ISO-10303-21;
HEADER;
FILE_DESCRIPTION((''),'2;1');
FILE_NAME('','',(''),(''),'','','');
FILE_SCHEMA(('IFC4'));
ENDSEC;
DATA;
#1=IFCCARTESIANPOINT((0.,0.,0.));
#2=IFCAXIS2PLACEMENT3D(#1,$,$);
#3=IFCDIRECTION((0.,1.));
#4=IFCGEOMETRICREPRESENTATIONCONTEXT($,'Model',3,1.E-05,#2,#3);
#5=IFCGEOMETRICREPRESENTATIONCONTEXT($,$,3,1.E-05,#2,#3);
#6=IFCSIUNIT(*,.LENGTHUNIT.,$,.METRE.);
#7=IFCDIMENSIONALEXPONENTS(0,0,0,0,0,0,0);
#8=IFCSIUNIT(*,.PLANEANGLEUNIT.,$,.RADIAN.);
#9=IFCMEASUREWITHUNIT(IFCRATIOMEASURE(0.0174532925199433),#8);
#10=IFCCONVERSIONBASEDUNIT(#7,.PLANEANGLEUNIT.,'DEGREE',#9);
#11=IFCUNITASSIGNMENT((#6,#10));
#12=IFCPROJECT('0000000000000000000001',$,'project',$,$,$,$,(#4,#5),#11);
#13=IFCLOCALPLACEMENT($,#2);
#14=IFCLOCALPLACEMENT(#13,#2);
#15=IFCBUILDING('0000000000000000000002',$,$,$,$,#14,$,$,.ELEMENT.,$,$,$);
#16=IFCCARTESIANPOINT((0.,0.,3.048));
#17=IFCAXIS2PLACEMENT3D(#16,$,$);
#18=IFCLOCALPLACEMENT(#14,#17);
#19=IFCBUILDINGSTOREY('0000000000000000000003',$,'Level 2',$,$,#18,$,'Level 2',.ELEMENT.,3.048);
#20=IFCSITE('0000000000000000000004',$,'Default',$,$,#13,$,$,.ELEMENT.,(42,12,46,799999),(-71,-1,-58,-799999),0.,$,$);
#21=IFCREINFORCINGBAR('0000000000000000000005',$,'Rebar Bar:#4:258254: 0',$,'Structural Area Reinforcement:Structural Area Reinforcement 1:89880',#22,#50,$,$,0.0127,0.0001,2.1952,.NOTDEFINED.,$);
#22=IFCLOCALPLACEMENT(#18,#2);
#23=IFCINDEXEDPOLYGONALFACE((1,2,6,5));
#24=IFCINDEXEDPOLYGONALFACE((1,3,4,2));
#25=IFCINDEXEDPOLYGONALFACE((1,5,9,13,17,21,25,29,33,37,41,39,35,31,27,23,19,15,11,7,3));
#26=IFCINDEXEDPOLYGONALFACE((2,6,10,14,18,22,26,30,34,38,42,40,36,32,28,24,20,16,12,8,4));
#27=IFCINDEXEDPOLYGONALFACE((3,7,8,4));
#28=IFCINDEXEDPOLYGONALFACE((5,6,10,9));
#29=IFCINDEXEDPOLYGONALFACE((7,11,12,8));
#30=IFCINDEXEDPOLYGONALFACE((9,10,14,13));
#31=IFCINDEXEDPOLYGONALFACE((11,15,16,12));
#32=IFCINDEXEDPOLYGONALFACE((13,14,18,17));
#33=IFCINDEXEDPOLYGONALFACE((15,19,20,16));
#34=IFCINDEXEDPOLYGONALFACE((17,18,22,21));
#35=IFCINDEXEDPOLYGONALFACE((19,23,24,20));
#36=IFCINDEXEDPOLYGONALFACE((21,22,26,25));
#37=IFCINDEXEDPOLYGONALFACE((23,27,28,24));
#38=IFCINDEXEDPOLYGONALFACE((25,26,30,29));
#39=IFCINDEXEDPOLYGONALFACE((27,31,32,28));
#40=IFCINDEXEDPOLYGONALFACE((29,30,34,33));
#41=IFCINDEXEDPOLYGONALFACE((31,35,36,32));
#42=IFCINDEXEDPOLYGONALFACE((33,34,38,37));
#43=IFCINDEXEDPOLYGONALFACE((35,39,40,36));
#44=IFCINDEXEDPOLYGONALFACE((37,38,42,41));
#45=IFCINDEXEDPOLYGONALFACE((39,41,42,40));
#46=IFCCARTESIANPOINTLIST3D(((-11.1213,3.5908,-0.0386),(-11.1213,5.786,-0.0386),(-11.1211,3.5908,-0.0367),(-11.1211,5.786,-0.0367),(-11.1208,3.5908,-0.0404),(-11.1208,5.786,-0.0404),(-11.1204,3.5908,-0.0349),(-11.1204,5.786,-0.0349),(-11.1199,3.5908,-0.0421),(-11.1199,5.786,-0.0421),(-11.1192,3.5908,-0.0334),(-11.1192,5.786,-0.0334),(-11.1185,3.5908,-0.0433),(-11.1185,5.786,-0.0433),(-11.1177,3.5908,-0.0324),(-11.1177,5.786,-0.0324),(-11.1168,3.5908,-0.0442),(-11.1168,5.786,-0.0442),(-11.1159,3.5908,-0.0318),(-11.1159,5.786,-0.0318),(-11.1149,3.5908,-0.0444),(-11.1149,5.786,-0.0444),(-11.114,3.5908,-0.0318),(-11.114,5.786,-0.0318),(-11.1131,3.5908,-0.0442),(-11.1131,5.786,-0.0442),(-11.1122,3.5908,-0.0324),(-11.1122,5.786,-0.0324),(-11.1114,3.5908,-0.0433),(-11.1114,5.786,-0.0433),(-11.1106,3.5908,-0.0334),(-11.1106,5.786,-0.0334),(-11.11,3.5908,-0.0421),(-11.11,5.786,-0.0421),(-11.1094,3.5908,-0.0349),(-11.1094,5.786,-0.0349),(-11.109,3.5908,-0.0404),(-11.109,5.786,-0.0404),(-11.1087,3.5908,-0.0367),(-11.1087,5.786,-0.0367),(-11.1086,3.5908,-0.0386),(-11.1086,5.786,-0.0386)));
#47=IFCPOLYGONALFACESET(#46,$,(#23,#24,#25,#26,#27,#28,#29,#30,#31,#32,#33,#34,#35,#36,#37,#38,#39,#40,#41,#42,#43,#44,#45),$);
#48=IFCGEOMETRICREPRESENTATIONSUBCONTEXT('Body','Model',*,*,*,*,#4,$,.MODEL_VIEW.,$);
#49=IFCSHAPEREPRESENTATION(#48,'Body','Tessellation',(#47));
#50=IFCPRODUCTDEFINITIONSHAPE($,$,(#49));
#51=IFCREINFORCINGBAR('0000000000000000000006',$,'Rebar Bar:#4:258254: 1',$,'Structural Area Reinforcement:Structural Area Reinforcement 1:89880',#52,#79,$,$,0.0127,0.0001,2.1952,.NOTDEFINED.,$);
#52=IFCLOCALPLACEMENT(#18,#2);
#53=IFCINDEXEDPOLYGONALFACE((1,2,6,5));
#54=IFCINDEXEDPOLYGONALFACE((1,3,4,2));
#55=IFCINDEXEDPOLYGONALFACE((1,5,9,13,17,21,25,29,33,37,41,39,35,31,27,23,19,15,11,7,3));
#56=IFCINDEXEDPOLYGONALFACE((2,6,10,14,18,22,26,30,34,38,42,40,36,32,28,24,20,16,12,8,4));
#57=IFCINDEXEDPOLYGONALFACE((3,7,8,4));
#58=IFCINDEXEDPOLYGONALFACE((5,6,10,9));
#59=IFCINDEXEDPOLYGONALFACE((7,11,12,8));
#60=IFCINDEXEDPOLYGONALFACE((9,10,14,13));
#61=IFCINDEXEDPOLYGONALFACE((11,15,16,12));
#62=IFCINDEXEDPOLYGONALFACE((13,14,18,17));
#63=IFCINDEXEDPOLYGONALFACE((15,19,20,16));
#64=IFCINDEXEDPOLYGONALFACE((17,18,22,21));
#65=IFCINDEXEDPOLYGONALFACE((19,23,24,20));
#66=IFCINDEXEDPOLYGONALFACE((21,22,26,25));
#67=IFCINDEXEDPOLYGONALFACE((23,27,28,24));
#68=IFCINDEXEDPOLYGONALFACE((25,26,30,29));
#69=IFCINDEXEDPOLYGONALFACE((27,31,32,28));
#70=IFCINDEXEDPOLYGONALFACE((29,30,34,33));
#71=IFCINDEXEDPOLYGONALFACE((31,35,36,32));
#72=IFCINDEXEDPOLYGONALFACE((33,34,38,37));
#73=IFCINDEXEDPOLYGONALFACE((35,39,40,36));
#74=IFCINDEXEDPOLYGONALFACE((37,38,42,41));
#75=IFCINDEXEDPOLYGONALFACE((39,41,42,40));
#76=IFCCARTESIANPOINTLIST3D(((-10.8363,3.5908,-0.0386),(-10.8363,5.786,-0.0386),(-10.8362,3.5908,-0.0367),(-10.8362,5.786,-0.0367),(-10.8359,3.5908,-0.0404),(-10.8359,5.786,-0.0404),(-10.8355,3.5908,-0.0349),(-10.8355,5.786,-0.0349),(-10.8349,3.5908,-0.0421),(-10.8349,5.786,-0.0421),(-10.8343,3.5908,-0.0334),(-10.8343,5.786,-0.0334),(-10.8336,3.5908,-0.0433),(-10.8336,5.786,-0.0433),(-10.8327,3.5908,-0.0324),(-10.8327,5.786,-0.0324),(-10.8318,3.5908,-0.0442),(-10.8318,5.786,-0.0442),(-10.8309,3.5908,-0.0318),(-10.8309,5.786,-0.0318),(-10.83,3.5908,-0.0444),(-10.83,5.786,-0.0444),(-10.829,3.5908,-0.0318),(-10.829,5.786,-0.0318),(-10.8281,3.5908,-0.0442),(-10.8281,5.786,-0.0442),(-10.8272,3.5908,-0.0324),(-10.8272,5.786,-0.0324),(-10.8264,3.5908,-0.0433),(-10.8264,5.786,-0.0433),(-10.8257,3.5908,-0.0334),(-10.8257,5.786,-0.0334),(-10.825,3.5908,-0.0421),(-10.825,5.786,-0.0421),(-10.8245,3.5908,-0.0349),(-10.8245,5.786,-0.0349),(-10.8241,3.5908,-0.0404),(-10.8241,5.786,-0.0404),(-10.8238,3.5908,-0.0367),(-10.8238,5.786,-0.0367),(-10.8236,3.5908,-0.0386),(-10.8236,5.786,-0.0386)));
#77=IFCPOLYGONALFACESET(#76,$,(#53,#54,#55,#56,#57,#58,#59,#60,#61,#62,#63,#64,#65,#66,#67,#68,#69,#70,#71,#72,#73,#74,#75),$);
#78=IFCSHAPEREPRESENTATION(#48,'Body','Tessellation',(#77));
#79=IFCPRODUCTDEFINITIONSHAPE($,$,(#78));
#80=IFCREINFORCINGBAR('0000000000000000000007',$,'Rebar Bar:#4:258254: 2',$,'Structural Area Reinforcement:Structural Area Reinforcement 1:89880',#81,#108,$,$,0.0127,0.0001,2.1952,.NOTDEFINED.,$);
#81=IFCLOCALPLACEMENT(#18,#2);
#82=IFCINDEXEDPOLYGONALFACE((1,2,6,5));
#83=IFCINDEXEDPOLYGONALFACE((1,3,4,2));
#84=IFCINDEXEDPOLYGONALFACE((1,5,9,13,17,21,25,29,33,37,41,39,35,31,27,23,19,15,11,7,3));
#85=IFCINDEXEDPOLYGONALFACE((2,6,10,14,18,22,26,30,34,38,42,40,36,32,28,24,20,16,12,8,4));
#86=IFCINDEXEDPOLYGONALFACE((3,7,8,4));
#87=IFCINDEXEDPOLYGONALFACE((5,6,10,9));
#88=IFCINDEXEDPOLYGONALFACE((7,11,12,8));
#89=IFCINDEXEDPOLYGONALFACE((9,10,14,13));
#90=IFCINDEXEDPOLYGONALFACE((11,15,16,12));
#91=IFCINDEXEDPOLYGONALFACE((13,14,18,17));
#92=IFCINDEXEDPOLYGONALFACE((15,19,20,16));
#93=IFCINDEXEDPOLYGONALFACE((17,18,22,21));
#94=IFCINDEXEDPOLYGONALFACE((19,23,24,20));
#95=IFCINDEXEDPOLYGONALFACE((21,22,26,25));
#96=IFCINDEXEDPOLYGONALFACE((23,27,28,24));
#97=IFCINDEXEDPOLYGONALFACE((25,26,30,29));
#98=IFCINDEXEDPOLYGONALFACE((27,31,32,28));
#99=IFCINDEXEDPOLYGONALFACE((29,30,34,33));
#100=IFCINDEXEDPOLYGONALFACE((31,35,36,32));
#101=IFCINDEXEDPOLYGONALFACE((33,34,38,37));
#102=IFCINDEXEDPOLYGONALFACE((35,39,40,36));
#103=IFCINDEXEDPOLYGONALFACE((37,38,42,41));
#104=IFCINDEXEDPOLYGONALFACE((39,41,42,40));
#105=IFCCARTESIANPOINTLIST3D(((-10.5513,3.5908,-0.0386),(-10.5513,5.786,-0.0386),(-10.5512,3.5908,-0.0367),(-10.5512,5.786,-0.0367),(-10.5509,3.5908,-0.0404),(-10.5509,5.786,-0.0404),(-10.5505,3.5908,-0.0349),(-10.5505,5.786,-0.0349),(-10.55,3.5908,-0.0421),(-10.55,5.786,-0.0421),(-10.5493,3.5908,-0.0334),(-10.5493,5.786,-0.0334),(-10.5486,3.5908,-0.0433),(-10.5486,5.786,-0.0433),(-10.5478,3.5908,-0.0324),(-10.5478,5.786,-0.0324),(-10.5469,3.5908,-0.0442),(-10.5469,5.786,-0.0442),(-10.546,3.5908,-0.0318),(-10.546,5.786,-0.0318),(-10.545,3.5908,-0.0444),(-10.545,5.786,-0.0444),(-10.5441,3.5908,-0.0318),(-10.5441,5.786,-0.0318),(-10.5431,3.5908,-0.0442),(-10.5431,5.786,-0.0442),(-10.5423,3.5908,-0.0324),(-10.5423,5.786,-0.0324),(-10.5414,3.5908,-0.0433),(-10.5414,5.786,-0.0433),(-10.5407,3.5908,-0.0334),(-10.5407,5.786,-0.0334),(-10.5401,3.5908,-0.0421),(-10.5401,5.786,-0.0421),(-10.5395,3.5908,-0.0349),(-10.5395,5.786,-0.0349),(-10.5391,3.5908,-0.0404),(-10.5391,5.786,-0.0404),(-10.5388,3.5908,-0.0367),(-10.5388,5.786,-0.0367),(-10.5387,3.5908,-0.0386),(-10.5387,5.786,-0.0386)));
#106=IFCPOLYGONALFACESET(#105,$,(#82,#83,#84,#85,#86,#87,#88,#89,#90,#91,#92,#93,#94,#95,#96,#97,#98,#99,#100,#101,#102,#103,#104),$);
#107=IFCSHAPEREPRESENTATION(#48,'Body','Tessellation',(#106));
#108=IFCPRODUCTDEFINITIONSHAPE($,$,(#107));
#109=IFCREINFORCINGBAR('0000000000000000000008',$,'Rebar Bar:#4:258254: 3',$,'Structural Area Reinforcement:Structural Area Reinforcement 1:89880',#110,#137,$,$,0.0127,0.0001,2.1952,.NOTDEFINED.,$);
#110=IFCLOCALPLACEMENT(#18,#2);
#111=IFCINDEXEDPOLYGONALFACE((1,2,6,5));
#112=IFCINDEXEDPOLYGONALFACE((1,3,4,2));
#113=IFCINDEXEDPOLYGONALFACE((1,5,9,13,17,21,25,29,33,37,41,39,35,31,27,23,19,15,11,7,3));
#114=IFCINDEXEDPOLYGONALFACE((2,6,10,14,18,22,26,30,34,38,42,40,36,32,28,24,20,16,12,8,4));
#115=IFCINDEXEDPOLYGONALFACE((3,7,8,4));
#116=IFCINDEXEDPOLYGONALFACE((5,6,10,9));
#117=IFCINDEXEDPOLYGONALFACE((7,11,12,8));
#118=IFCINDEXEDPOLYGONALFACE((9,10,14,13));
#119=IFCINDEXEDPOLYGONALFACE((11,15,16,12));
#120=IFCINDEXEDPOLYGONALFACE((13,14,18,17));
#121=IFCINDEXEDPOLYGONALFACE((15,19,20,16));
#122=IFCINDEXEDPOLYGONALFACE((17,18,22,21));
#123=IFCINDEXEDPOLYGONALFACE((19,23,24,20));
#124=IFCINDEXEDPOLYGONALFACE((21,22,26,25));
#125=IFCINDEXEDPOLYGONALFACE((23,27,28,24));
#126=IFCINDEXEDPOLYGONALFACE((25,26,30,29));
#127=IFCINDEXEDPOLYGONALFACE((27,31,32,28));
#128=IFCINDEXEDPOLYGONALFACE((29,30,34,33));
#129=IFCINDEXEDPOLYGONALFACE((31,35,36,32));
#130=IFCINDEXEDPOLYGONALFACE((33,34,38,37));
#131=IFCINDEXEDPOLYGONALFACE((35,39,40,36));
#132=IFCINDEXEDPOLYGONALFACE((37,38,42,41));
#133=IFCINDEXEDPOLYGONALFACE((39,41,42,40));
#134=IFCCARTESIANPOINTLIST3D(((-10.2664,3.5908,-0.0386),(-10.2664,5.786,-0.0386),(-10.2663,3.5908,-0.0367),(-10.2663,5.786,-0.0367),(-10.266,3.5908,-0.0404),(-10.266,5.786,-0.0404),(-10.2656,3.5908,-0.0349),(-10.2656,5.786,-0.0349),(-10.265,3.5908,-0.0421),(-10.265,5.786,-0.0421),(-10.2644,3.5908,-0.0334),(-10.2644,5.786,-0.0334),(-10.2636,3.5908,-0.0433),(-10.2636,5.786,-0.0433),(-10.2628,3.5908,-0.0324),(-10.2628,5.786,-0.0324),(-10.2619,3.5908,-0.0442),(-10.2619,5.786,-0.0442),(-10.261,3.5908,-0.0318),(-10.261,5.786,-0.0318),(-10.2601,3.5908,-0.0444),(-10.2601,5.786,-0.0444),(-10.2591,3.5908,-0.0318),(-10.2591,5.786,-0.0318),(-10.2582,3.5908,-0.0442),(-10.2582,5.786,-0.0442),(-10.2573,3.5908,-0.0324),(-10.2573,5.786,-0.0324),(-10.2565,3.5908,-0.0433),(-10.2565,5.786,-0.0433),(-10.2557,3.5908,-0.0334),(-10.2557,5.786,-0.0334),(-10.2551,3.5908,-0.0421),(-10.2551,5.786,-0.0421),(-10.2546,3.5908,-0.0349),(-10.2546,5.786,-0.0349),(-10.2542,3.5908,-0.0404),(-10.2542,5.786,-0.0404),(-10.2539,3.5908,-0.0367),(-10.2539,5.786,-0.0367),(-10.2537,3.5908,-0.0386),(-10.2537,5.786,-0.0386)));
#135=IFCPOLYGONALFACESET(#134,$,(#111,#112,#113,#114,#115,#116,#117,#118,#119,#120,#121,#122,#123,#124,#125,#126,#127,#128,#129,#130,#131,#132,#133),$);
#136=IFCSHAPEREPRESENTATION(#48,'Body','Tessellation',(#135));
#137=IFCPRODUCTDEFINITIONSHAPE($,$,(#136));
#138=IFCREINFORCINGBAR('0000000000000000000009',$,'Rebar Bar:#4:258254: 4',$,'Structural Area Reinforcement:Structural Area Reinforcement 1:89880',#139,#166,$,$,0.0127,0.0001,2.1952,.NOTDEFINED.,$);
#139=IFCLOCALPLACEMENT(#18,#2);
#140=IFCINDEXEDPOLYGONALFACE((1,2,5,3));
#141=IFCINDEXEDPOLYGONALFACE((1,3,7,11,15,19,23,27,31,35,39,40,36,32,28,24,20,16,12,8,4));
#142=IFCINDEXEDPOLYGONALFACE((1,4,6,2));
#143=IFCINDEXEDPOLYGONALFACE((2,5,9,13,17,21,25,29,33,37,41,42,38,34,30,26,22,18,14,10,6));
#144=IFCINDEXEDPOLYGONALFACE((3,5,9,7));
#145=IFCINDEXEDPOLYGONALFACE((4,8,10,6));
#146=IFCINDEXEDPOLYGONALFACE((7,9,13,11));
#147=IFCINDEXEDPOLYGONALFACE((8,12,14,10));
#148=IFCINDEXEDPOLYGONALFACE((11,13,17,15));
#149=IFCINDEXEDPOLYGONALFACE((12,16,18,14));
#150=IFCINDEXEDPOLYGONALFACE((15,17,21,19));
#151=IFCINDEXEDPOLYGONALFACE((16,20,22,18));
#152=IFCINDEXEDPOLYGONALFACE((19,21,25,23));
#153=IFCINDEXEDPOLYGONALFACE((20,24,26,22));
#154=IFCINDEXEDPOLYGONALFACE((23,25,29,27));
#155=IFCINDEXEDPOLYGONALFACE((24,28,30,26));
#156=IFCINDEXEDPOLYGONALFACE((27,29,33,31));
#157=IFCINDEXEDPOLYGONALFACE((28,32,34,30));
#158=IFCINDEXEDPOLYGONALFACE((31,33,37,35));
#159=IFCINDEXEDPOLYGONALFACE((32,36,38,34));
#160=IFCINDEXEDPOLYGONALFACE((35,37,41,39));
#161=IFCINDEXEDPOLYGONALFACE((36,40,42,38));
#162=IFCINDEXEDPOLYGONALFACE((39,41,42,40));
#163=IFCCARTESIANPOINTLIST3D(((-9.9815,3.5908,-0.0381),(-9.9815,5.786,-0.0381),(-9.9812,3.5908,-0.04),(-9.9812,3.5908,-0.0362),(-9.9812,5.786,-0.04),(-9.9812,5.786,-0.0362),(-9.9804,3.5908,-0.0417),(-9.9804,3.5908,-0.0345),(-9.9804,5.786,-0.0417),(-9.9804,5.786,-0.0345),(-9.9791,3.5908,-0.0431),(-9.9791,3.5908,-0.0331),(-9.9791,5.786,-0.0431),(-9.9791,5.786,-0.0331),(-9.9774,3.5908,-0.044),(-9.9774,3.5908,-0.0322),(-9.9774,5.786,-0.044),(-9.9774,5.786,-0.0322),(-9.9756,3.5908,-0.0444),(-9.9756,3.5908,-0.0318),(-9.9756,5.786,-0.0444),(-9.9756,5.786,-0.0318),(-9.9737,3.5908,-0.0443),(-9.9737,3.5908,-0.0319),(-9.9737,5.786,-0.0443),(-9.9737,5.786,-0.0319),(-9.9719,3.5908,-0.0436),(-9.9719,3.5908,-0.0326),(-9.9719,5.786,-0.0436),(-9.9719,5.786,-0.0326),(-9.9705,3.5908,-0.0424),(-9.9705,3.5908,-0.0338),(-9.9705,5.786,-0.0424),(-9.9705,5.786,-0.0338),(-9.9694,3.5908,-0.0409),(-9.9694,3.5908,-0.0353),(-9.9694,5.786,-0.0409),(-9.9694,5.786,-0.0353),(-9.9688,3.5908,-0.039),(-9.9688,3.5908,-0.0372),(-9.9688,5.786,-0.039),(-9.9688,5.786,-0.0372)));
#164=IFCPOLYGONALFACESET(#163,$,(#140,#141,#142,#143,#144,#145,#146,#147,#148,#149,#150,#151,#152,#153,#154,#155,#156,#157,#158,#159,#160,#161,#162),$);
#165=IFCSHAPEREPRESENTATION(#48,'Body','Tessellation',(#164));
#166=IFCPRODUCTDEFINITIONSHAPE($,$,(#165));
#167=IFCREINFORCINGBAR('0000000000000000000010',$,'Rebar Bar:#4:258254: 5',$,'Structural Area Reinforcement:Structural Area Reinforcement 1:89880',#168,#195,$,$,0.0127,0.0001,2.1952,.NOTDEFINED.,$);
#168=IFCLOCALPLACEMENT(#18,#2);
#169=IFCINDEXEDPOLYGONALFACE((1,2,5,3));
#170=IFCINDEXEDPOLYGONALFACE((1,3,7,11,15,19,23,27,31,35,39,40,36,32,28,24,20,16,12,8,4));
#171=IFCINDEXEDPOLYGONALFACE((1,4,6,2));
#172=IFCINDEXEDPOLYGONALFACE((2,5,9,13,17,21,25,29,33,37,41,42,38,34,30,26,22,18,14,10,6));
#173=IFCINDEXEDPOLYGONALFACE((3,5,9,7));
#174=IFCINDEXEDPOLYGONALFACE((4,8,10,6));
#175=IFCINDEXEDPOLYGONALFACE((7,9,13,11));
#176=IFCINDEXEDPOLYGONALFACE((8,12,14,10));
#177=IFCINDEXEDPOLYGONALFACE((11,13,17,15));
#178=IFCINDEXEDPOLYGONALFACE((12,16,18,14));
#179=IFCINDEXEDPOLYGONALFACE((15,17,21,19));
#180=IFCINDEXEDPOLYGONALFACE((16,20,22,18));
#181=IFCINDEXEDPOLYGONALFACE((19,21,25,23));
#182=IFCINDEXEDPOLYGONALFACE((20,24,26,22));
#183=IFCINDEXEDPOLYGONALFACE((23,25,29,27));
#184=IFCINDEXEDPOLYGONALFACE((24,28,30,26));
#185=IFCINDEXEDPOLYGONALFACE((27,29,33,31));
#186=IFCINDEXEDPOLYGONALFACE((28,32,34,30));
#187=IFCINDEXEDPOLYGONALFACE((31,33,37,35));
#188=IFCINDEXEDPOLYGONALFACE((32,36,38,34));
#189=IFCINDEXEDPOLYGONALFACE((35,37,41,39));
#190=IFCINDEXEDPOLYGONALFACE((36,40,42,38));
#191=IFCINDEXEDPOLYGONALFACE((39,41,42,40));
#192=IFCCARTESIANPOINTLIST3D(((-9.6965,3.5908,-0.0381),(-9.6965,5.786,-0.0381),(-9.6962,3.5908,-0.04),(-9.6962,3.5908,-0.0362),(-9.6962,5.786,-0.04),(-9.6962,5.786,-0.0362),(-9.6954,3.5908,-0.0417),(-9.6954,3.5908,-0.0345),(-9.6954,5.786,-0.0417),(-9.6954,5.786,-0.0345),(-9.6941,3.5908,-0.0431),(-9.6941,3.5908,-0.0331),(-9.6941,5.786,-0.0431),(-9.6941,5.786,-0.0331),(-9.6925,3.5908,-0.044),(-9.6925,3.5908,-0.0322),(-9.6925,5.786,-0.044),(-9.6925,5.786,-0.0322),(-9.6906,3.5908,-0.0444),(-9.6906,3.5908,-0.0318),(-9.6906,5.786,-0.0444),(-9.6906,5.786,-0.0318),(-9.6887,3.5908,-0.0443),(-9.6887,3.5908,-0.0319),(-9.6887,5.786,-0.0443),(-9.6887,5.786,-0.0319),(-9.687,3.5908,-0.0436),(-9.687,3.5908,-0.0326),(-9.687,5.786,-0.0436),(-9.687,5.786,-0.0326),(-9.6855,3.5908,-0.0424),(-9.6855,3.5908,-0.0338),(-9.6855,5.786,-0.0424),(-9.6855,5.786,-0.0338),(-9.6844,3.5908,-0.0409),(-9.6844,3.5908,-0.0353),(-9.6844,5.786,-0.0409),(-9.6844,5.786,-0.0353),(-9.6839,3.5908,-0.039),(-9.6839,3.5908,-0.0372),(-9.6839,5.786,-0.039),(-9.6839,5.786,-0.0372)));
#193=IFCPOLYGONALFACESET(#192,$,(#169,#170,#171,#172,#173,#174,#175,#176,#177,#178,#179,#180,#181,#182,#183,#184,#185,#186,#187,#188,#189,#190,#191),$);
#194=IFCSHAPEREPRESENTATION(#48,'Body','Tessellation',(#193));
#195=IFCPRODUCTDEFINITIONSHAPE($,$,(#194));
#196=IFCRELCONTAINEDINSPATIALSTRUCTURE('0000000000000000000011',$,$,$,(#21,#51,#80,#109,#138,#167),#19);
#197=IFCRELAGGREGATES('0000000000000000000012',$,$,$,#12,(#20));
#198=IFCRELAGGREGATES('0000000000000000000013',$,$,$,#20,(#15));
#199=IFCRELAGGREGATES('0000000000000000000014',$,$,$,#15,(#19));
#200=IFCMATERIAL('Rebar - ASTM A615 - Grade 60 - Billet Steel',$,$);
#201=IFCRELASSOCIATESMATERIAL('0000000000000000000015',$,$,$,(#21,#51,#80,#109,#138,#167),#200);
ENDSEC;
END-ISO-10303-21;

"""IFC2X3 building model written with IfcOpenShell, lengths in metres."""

from ifc_helpers import new_model, entity, si_unit, converted_unit, direction, frame, origin, place, context, subcontext, project, spatial, material, element, save


model = new_model("IFC2X3")

# Units and contexts
model_context = context("Model", 3, precision=1e-05, world=origin(), true_north=direction((0.0, 1.0)))
context_of_model = context(None, 3, precision=1e-05, world=origin(), true_north=direction((0.0, 1.0)))
body_context = subcontext(model_context, "Body", "Model", "MODEL_VIEW")
ifc_project = project(units=[si_unit("LENGTHUNIT", "METRE"), converted_unit("PLANEANGLEUNIT", "DEGREE", entity("IfcRatioMeasure", 0.0174532925199433), si_unit("PLANEANGLEUNIT", "RADIAN"), dimensions=[0, 0, 0, 0, 0, 0, 0])], contexts=[model_context, context_of_model])

# Site, building, storey
site_placement = place(None, origin())
site = spatial("IfcSite", under=ifc_project, at=site_placement, Name="Default", CompositionType="ELEMENT", RefLatitude=(42, 12, 46, 799999), RefLongitude=(-71, -1, -58, -799999), RefElevation=0.0)
building_placement = place(site_placement, origin())
building = spatial("IfcBuilding", under=site, at=building_placement, CompositionType="ELEMENT")
storey_placement = place(building_placement, frame((0.0, 0.0, 3.048)))
storey = spatial("IfcBuildingStorey", under=building, at=storey_placement, Name="Level 2", LongName="Level 2", CompositionType="ELEMENT", Elevation=3.048)

# Reinforcing bars
ifc_material_1 = material(Name="Rebar - ASTM A615 - Grade 60 - Billet Steel")
reinforcing_bar_1_placement = place(storey_placement, origin())
element("IfcReinforcingBar", 1, at=reinforcing_bar_1_placement, inside=storey, material=ifc_material_1, Name="Rebar Bar:#4:258254: 0", ObjectType="Structural Area Reinforcement:Structural Area Reinforcement 1:89880", BarLength=2.1952, BarRole="NOTDEFINED", CrossSectionArea=0.0001, NominalDiameter=0.0127, context=body_context, shape_type="AdvancedSweptSolid", body=[
    entity("IfcSweptDiskSolid", entity("IfcCompositeCurve", [entity("IfcCompositeCurveSegment", "CONTINUOUS", True, entity("IfcPolyline", [entity("IfcCartesianPoint", [-11.1149, 5.786, -0.0381]), entity("IfcCartesianPoint", [-11.1149, 3.5908, -0.0381])]))], False), 0.0063, None, 0.0, 1.0),
])
reinforcing_bar_2_placement = place(storey_placement, origin())
element("IfcReinforcingBar", 2, at=reinforcing_bar_2_placement, inside=storey, material=ifc_material_1, Name="Rebar Bar:#4:258254: 1", ObjectType="Structural Area Reinforcement:Structural Area Reinforcement 1:89880", BarLength=2.1952, BarRole="NOTDEFINED", CrossSectionArea=0.0001, NominalDiameter=0.0127, context=body_context, shape_type="AdvancedSweptSolid", body=[
    entity("IfcSweptDiskSolid", entity("IfcCompositeCurve", [entity("IfcCompositeCurveSegment", "CONTINUOUS", True, entity("IfcPolyline", [entity("IfcCartesianPoint", [-10.83, 5.786, -0.0381]), entity("IfcCartesianPoint", [-10.83, 3.5908, -0.0381])]))], False), 0.0063, None, 0.0, 1.0),
])
reinforcing_bar_3_placement = place(storey_placement, origin())
element("IfcReinforcingBar", 3, at=reinforcing_bar_3_placement, inside=storey, material=ifc_material_1, Name="Rebar Bar:#4:258254: 2", ObjectType="Structural Area Reinforcement:Structural Area Reinforcement 1:89880", BarLength=2.1952, BarRole="NOTDEFINED", CrossSectionArea=0.0001, NominalDiameter=0.0127, context=body_context, shape_type="AdvancedSweptSolid", body=[
    entity("IfcSweptDiskSolid", entity("IfcCompositeCurve", [entity("IfcCompositeCurveSegment", "CONTINUOUS", True, entity("IfcPolyline", [entity("IfcCartesianPoint", [-10.545, 5.786, -0.0381]), entity("IfcCartesianPoint", [-10.545, 3.5908, -0.0381])]))], False), 0.0063, None, 0.0, 1.0),
])
reinforcing_bar_4_placement = place(storey_placement, origin())
element("IfcReinforcingBar", 4, at=reinforcing_bar_4_placement, inside=storey, material=ifc_material_1, Name="Rebar Bar:#4:258254: 3", ObjectType="Structural Area Reinforcement:Structural Area Reinforcement 1:89880", BarLength=2.1952, BarRole="NOTDEFINED", CrossSectionArea=0.0001, NominalDiameter=0.0127, context=body_context, shape_type="AdvancedSweptSolid", body=[
    entity("IfcSweptDiskSolid", entity("IfcCompositeCurve", [entity("IfcCompositeCurveSegment", "CONTINUOUS", True, entity("IfcPolyline", [entity("IfcCartesianPoint", [-10.2601, 5.786, -0.0381]), entity("IfcCartesianPoint", [-10.2601, 3.5908, -0.0381])]))], False), 0.0063, None, 0.0, 1.0),
])
reinforcing_bar_5_placement = place(storey_placement, origin())
element("IfcReinforcingBar", 5, at=reinforcing_bar_5_placement, inside=storey, material=ifc_material_1, Name="Rebar Bar:#4:258254: 4", ObjectType="Structural Area Reinforcement:Structural Area Reinforcement 1:89880", BarLength=2.1952, BarRole="NOTDEFINED", CrossSectionArea=0.0001, NominalDiameter=0.0127, context=body_context, shape_type="AdvancedSweptSolid", body=[
    entity("IfcSweptDiskSolid", entity("IfcCompositeCurve", [entity("IfcCompositeCurveSegment", "CONTINUOUS", True, entity("IfcPolyline", [entity("IfcCartesianPoint", [-9.9751, 5.786, -0.0381]), entity("IfcCartesianPoint", [-9.9751, 3.5908, -0.0381])]))], False), 0.0063, None, 0.0, 1.0),
])
reinforcing_bar_6_placement = place(storey_placement, origin())
element("IfcReinforcingBar", 6, at=reinforcing_bar_6_placement, inside=storey, material=ifc_material_1, Name="Rebar Bar:#4:258254: 5", ObjectType="Structural Area Reinforcement:Structural Area Reinforcement 1:89880", BarLength=2.1952, BarRole="NOTDEFINED", CrossSectionArea=0.0001, NominalDiameter=0.0127, context=body_context, shape_type="AdvancedSweptSolid", body=[
    entity("IfcSweptDiskSolid", entity("IfcCompositeCurve", [entity("IfcCompositeCurveSegment", "CONTINUOUS", True, entity("IfcPolyline", [entity("IfcCartesianPoint", [-9.6901, 5.786, -0.0381]), entity("IfcCartesianPoint", [-9.6901, 3.5908, -0.0381])]))], False), 0.0063, None, 0.0, 1.0),
])

save(model, "model.ifc")
